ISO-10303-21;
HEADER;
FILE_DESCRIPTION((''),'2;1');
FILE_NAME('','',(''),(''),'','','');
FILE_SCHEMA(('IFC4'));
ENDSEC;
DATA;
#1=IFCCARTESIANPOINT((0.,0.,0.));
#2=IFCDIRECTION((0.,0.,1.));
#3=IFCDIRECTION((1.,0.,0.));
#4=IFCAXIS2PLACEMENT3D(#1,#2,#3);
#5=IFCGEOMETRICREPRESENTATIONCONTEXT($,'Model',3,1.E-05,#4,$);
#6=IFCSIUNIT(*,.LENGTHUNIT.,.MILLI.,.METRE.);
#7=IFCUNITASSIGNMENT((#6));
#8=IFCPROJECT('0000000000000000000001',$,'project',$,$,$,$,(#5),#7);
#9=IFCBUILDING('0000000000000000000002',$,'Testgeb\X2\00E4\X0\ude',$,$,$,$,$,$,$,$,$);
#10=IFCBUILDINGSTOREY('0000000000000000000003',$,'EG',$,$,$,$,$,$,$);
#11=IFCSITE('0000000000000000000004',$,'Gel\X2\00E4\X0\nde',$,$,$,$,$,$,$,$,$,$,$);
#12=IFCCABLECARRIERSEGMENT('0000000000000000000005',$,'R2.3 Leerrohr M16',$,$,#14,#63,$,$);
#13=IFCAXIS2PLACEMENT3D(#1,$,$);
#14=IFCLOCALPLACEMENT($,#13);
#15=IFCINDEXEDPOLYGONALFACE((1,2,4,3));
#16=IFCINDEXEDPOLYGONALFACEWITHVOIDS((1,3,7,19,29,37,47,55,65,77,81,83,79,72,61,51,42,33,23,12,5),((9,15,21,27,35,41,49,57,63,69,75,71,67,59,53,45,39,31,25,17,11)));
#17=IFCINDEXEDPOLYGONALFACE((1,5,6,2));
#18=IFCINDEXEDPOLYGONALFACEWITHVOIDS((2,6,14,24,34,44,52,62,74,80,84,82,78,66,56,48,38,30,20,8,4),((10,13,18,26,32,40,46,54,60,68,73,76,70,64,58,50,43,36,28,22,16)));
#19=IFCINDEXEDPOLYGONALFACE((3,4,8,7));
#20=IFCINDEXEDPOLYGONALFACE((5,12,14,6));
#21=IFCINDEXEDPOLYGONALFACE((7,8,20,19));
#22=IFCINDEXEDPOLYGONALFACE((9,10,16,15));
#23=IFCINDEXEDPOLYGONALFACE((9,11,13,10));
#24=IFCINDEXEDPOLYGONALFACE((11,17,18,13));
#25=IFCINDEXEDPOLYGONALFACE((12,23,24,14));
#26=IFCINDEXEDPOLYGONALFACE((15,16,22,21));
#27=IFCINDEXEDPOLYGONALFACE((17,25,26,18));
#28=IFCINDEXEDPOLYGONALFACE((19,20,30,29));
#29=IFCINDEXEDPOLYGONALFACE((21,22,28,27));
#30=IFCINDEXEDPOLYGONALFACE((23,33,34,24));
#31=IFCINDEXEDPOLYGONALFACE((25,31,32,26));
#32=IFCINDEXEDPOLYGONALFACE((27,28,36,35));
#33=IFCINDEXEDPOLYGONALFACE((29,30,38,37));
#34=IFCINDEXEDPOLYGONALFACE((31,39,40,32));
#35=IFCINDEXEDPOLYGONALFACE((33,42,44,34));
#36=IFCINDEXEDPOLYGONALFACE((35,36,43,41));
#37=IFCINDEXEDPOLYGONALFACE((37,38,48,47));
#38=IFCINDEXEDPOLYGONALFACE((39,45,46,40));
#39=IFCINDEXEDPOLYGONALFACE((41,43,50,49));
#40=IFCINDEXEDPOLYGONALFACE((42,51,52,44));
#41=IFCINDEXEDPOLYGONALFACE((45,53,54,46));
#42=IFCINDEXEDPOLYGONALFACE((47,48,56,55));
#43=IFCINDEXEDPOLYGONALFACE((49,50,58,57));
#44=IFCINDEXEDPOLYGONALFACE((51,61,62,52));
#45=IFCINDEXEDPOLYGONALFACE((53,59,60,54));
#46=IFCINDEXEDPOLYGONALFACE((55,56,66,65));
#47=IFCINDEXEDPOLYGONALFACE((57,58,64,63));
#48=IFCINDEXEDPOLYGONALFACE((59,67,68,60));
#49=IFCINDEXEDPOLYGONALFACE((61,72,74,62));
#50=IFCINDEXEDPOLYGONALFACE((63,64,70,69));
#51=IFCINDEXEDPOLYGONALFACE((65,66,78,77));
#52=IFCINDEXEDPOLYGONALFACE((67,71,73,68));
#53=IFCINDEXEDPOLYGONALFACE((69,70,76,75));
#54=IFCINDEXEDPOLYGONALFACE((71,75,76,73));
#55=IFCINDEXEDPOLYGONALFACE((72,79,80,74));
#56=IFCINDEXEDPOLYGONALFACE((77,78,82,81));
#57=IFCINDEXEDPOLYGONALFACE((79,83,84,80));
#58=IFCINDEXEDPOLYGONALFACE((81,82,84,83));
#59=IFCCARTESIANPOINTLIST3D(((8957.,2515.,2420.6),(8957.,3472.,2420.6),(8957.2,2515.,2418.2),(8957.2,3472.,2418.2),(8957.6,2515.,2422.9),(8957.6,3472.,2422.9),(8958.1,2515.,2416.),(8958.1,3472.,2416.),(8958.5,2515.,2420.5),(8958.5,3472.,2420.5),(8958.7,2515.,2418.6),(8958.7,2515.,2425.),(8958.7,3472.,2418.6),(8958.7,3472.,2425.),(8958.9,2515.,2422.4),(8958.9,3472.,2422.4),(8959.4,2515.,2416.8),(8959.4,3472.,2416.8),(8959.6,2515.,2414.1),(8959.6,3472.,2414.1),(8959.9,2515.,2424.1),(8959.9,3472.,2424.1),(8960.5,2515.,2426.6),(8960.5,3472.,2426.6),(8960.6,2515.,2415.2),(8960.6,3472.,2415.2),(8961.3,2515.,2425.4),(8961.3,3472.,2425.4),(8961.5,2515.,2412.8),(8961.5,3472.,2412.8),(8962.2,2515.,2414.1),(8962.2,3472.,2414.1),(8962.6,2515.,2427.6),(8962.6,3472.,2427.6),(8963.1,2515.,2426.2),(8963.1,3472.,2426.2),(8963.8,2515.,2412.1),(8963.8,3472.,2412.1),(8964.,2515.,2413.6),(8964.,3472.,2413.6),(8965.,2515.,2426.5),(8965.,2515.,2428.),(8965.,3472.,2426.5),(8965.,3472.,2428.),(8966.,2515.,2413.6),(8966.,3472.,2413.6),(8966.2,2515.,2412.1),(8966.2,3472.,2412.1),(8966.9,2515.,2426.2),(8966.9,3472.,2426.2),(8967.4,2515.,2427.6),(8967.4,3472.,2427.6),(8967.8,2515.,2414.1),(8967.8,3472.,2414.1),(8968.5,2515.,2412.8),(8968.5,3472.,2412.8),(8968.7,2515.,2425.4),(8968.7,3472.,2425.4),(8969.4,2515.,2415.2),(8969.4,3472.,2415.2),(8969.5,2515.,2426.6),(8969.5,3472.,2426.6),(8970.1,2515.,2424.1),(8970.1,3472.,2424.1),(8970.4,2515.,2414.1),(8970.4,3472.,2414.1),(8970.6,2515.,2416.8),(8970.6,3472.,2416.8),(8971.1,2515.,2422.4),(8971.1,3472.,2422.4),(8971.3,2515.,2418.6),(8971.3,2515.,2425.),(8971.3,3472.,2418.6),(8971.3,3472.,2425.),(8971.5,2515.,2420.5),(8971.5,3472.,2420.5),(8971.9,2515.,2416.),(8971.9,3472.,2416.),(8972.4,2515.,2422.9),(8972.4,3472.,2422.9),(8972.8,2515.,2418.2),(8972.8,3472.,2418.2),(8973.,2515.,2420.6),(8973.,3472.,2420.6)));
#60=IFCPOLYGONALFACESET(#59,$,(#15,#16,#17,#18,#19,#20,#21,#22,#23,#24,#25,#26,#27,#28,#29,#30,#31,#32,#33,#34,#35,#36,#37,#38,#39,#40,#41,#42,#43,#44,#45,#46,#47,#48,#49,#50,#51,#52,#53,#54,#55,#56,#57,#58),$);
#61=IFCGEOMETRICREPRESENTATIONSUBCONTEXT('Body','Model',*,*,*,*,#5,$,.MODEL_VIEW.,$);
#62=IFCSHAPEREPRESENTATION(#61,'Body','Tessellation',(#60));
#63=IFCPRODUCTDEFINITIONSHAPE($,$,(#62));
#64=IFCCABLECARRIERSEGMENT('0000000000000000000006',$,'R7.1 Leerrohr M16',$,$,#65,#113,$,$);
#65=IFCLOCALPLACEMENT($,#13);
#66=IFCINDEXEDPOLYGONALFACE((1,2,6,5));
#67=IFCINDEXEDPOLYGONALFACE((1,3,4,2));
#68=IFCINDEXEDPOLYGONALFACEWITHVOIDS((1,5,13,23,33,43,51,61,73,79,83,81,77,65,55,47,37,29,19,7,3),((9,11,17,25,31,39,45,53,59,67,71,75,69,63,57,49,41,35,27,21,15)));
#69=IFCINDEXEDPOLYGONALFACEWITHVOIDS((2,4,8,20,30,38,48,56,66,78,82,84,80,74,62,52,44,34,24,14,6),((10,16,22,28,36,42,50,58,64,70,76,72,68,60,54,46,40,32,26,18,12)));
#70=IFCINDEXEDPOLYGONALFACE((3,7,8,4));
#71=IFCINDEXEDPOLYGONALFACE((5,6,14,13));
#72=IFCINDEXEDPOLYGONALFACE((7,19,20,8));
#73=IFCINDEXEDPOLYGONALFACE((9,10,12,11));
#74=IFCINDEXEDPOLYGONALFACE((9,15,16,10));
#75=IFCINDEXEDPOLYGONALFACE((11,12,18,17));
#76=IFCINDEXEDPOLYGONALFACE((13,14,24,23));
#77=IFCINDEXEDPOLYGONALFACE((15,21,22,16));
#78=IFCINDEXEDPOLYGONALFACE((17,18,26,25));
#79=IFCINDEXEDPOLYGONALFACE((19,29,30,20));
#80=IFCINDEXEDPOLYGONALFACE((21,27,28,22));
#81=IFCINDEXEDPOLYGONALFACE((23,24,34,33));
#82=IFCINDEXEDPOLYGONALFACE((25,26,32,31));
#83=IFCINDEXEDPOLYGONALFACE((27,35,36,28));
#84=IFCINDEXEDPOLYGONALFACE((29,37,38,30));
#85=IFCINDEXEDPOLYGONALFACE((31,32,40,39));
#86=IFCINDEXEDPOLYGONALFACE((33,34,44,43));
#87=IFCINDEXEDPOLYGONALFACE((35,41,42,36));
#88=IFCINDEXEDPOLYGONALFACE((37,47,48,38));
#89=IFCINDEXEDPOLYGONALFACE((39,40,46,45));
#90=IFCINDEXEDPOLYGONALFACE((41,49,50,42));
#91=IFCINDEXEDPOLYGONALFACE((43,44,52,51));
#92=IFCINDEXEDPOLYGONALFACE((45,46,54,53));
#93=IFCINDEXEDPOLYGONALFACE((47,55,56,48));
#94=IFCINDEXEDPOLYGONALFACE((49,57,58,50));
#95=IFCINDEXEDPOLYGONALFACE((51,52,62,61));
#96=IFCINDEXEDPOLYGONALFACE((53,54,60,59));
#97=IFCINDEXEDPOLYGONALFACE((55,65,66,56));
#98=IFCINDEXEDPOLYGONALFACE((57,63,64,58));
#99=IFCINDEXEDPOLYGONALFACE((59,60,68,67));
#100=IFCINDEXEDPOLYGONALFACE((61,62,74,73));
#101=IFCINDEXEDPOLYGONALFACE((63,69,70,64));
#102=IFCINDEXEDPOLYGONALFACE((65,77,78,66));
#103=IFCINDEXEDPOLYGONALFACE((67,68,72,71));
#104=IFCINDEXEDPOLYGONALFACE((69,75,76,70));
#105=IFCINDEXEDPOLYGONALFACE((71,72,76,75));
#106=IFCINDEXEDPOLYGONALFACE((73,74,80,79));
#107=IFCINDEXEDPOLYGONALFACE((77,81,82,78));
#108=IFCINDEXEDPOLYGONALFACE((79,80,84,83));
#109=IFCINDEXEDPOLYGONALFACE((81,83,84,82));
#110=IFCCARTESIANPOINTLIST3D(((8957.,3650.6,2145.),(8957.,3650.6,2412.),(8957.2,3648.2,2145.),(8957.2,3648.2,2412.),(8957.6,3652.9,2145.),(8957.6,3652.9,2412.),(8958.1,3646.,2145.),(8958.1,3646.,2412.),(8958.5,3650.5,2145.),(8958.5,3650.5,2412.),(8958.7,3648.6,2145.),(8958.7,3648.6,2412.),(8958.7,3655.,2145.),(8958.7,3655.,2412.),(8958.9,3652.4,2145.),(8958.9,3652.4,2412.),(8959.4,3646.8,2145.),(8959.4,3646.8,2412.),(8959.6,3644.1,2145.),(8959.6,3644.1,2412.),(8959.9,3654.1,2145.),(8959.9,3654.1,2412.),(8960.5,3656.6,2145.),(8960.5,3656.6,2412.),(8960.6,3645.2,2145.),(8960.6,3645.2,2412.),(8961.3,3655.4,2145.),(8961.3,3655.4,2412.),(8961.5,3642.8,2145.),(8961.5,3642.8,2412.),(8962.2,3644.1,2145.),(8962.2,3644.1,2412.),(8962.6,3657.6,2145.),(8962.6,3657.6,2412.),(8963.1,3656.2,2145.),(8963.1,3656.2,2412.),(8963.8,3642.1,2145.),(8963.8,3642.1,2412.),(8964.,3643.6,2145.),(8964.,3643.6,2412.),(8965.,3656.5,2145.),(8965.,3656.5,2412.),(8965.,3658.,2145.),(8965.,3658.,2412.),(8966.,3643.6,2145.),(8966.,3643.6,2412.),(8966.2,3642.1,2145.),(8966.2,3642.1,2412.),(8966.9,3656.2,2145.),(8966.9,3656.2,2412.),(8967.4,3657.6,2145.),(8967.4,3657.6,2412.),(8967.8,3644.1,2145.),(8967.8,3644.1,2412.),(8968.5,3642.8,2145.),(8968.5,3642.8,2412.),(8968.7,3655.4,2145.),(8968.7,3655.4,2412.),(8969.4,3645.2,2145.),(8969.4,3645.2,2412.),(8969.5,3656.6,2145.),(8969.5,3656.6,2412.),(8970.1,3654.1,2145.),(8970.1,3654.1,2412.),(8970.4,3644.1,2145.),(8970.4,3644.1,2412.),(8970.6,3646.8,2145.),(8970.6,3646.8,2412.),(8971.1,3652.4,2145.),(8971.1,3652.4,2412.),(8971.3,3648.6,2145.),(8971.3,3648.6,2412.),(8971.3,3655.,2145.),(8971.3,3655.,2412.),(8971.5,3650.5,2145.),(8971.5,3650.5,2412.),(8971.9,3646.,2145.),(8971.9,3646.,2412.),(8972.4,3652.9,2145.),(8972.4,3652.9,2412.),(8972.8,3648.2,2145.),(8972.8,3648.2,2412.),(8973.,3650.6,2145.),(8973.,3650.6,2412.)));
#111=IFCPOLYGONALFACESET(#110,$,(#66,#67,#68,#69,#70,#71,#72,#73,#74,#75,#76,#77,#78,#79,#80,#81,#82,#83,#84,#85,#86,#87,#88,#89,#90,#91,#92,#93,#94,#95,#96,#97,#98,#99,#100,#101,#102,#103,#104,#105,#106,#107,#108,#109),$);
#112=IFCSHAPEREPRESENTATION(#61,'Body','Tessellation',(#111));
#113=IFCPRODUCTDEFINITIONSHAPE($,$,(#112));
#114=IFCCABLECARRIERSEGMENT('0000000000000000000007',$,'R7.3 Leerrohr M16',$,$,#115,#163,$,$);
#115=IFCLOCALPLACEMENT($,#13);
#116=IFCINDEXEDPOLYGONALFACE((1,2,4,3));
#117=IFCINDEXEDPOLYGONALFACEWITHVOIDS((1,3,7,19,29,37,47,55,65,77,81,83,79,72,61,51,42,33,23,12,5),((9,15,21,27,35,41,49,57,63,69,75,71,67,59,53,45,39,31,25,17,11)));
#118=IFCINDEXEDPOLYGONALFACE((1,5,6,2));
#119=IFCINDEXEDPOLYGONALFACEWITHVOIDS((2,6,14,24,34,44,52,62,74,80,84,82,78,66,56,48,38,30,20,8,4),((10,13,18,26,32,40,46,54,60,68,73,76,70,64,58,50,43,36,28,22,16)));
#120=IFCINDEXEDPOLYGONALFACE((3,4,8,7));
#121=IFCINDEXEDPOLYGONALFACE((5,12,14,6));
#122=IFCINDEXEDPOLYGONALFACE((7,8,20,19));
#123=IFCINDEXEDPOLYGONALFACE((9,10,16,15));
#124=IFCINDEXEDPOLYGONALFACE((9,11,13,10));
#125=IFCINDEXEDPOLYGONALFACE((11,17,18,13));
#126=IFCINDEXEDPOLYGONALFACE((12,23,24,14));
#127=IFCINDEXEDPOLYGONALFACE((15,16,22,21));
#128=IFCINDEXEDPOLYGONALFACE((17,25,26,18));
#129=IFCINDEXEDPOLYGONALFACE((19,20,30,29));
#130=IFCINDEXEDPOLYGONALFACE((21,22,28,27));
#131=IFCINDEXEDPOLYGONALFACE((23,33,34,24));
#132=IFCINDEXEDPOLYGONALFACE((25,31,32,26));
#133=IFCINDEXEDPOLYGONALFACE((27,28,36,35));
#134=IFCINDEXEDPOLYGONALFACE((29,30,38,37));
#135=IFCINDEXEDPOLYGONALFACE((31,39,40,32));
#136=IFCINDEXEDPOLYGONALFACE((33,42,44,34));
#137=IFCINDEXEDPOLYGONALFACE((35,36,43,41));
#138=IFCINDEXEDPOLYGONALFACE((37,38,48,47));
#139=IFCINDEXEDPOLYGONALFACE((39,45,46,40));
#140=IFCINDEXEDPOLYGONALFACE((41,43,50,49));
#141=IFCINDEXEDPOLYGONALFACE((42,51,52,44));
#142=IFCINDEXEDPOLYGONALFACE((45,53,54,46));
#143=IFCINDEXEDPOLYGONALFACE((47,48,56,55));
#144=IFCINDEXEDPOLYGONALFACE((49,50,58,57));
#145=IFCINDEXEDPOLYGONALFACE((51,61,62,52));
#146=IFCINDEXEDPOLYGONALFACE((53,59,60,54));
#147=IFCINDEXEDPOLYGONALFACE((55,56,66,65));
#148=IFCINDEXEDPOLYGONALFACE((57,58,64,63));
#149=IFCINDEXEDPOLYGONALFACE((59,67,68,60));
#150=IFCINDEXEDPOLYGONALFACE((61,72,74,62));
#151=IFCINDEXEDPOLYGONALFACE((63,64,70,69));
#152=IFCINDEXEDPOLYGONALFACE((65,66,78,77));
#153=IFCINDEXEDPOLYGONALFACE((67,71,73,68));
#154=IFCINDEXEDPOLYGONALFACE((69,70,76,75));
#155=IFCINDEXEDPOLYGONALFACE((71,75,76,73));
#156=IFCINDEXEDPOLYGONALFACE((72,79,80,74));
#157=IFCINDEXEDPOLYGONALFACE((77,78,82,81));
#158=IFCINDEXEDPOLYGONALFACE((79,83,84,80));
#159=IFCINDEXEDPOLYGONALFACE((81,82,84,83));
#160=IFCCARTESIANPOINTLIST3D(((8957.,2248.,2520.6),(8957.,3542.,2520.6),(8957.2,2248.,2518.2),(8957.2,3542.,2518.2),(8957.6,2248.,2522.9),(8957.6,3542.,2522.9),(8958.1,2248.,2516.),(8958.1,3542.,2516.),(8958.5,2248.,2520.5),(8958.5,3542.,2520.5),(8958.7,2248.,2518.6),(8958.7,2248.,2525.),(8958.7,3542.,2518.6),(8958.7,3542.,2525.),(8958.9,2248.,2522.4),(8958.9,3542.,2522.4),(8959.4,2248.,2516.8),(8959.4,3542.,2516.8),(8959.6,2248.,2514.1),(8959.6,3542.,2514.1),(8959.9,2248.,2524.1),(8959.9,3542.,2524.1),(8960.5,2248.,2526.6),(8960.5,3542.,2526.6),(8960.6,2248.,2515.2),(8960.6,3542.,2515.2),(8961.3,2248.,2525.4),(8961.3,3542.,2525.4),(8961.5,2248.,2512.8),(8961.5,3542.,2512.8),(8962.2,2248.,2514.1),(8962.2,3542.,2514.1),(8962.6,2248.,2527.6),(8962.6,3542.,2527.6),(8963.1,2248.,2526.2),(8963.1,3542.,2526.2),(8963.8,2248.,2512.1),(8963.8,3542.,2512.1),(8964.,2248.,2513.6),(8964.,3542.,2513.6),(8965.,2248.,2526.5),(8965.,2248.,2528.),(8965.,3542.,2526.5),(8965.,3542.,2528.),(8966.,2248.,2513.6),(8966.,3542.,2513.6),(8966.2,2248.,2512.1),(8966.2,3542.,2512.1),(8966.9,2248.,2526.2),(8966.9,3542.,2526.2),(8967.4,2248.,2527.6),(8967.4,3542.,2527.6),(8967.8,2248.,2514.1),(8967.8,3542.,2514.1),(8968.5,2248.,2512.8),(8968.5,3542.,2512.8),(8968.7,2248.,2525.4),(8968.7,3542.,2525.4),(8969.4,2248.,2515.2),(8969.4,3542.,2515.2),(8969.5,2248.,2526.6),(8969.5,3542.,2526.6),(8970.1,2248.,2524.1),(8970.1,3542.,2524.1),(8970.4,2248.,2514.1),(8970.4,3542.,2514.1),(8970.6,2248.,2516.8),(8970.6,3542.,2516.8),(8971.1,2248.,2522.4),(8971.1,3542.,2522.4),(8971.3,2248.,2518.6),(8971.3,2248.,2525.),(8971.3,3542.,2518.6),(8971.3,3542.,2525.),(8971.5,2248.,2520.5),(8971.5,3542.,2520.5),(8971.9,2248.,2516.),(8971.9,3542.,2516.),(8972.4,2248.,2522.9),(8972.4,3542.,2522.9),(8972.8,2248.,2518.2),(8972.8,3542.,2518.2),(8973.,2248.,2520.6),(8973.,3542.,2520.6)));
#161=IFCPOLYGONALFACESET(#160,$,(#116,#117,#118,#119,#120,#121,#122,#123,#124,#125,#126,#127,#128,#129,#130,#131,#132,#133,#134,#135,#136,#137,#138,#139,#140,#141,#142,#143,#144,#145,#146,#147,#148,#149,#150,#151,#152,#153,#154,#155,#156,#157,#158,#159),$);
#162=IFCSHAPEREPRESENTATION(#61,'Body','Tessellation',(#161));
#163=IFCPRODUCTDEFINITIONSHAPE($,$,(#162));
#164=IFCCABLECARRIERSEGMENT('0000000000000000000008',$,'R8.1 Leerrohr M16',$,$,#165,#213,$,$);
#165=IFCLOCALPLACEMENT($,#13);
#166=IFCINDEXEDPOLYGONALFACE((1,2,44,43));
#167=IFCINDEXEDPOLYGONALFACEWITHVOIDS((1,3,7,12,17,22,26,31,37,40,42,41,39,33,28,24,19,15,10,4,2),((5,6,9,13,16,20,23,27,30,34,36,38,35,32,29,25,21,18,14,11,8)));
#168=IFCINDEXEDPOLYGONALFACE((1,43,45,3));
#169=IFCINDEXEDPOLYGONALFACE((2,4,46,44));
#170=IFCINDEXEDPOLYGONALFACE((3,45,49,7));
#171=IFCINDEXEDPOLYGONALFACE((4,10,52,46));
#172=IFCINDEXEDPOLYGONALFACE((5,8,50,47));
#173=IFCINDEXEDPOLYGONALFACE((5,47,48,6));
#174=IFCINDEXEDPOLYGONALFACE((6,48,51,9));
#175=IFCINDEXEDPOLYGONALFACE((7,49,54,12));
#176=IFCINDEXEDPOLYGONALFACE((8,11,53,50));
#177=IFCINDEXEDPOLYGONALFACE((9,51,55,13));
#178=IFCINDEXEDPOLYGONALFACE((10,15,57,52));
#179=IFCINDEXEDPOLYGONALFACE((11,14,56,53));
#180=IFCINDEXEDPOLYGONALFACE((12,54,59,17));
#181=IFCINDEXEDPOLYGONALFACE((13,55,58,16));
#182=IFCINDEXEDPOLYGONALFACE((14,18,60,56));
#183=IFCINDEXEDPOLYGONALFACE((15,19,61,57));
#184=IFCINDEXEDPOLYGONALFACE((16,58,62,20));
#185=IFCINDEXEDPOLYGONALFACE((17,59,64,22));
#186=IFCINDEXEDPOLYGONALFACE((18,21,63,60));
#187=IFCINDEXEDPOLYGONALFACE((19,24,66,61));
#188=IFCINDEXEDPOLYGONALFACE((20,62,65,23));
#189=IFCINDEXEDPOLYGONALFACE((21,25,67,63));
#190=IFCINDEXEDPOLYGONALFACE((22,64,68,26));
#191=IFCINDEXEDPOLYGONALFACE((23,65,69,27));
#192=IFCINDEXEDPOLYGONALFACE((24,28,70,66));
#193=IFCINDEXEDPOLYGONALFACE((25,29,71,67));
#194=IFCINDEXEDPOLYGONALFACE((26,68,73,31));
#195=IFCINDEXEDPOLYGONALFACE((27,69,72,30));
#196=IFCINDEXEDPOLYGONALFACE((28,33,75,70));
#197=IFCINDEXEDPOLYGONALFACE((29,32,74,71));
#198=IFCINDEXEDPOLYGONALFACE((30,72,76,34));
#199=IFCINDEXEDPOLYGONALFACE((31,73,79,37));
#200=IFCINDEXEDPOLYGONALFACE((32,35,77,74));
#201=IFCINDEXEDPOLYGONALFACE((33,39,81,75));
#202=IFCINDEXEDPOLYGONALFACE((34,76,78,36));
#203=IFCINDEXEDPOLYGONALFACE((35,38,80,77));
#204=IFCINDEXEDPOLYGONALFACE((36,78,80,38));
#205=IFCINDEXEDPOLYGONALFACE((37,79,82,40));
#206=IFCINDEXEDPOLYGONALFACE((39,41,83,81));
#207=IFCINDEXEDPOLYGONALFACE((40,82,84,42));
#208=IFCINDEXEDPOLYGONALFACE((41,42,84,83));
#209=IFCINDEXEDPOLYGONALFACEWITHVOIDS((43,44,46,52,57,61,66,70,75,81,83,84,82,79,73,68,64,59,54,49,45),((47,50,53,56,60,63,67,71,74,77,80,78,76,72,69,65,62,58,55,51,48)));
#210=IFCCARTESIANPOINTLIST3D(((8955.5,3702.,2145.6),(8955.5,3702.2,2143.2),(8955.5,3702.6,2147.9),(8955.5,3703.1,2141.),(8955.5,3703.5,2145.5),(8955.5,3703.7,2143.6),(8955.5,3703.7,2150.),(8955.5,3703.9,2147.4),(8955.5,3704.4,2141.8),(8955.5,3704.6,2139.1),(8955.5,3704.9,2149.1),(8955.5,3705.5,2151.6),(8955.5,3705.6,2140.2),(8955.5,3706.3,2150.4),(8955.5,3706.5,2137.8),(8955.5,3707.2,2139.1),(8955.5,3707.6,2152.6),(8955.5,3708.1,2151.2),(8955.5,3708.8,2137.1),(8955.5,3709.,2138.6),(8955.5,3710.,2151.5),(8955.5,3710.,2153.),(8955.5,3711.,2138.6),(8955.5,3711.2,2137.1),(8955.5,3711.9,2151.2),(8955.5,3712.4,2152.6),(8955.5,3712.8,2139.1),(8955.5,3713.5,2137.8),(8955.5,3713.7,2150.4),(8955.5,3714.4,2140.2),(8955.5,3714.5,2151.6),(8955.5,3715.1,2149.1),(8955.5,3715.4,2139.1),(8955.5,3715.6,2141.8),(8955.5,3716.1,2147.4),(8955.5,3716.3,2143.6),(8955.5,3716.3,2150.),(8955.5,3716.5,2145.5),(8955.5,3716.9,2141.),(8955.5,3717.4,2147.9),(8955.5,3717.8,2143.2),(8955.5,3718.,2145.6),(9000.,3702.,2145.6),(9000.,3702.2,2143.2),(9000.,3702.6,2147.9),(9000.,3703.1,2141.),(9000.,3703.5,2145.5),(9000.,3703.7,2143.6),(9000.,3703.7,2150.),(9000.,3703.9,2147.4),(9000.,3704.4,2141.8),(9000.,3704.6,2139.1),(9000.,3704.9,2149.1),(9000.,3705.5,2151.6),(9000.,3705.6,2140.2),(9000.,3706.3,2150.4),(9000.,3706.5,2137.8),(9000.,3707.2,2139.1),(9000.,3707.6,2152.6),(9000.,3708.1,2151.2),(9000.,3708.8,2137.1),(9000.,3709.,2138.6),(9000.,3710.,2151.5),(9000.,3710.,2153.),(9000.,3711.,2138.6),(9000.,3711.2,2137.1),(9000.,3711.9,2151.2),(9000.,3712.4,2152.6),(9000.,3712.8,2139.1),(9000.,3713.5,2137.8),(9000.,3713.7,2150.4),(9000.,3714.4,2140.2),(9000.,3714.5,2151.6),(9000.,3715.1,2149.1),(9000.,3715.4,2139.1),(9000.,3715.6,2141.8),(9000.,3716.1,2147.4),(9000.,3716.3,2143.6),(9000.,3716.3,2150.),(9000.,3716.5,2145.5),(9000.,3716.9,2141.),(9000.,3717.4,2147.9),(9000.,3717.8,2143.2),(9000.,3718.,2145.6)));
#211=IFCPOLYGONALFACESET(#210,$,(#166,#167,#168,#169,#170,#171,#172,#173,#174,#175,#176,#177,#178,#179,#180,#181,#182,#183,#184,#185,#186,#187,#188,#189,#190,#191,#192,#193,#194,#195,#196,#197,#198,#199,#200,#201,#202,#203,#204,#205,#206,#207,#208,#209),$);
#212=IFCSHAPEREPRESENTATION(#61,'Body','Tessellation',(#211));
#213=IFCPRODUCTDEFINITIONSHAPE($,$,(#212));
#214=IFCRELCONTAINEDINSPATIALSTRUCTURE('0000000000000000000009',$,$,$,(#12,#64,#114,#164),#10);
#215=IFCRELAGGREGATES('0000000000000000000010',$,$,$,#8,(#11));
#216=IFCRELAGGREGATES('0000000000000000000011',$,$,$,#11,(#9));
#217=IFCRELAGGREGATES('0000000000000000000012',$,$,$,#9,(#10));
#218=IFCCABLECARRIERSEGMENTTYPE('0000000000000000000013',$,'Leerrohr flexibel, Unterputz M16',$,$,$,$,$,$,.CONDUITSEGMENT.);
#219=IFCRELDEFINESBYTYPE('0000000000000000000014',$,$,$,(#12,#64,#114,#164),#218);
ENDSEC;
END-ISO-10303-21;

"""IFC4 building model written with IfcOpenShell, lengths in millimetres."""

from ifc_helpers import new_model, si_unit, frame, origin_with_axes, place, context, subcontext, project, spatial, hollow_circle, extrude, type_object, element, save


model = new_model("IFC4")

# Units and contexts
model_context = context("Model", 3, precision=1e-05, world=origin_with_axes())
body_context = subcontext(model_context, "Body", "Model", "MODEL_VIEW")
ifc_project = project(units=[si_unit("LENGTHUNIT", "METRE", prefix="MILLI")], contexts=[model_context])

# Site, building, storey
site = spatial("IfcSite", under=ifc_project, Name="Gelände")
building = spatial("IfcBuilding", under=site, Name="Testgebäude")
storey = spatial("IfcBuildingStorey", under=building, Name="EG")

# Cable carrier segments
cable_carrier_segment_type_1 = type_object("IfcCableCarrierSegmentType", Name="Leerrohr flexibel, Unterputz M16", PredefinedType="CONDUITSEGMENT")
cable_carrier_segment_1_placement = place(None, frame((8965.0, 3472.0, 2420.0), z_axis=(0.0, -1.0, 0.0), x_axis=(0.0, 0.0, 1.0)))
element("IfcCableCarrierSegment", 1, at=cable_carrier_segment_1_placement, inside=storey, type_object=cable_carrier_segment_type_1, Name="R2.3 Leerrohr M16", context=body_context, shape_type="SweptSolid", body=[
    extrude(hollow_circle(Radius=8.0, WallThickness=1.5), None, (0.0, 0.0, 1.0), 957.0),
])
cable_carrier_segment_2_placement = place(None, frame((8965.0, 3650.0, 2145.0), z_axis=(0.0, 0.0, 1.0), x_axis=(0.0, 1.0, 0.0)))
element("IfcCableCarrierSegment", 2, at=cable_carrier_segment_2_placement, inside=storey, type_object=cable_carrier_segment_type_1, Name="R7.1 Leerrohr M16", context=body_context, shape_type="SweptSolid", body=[
    extrude(hollow_circle(Radius=8.0, WallThickness=1.5), None, (0.0, 0.0, 1.0), 267.0),
])
cable_carrier_segment_3_placement = place(None, frame((8965.0, 3542.0, 2520.0), z_axis=(0.0, -1.0, 0.0), x_axis=(0.0, 0.0, 1.0)))
element("IfcCableCarrierSegment", 3, at=cable_carrier_segment_3_placement, inside=storey, type_object=cable_carrier_segment_type_1, Name="R7.3 Leerrohr M16", context=body_context, shape_type="SweptSolid", body=[
    extrude(hollow_circle(Radius=8.0, WallThickness=1.5), None, (0.0, 0.0, 1.0), 1294.0),
])
cable_carrier_segment_4_placement = place(None, frame((9000.0, 3710.0, 2145.0), z_axis=(-1.0, 0.0, 0.0), x_axis=(0.0, 0.0, 1.0)))
element("IfcCableCarrierSegment", 4, at=cable_carrier_segment_4_placement, inside=storey, type_object=cable_carrier_segment_type_1, Name="R8.1 Leerrohr M16", context=body_context, shape_type="SweptSolid", body=[
    extrude(hollow_circle(Radius=8.0, WallThickness=1.5), None, (0.0, 0.0, 1.0), 44.5),
])

save(model, "model.ifc")
